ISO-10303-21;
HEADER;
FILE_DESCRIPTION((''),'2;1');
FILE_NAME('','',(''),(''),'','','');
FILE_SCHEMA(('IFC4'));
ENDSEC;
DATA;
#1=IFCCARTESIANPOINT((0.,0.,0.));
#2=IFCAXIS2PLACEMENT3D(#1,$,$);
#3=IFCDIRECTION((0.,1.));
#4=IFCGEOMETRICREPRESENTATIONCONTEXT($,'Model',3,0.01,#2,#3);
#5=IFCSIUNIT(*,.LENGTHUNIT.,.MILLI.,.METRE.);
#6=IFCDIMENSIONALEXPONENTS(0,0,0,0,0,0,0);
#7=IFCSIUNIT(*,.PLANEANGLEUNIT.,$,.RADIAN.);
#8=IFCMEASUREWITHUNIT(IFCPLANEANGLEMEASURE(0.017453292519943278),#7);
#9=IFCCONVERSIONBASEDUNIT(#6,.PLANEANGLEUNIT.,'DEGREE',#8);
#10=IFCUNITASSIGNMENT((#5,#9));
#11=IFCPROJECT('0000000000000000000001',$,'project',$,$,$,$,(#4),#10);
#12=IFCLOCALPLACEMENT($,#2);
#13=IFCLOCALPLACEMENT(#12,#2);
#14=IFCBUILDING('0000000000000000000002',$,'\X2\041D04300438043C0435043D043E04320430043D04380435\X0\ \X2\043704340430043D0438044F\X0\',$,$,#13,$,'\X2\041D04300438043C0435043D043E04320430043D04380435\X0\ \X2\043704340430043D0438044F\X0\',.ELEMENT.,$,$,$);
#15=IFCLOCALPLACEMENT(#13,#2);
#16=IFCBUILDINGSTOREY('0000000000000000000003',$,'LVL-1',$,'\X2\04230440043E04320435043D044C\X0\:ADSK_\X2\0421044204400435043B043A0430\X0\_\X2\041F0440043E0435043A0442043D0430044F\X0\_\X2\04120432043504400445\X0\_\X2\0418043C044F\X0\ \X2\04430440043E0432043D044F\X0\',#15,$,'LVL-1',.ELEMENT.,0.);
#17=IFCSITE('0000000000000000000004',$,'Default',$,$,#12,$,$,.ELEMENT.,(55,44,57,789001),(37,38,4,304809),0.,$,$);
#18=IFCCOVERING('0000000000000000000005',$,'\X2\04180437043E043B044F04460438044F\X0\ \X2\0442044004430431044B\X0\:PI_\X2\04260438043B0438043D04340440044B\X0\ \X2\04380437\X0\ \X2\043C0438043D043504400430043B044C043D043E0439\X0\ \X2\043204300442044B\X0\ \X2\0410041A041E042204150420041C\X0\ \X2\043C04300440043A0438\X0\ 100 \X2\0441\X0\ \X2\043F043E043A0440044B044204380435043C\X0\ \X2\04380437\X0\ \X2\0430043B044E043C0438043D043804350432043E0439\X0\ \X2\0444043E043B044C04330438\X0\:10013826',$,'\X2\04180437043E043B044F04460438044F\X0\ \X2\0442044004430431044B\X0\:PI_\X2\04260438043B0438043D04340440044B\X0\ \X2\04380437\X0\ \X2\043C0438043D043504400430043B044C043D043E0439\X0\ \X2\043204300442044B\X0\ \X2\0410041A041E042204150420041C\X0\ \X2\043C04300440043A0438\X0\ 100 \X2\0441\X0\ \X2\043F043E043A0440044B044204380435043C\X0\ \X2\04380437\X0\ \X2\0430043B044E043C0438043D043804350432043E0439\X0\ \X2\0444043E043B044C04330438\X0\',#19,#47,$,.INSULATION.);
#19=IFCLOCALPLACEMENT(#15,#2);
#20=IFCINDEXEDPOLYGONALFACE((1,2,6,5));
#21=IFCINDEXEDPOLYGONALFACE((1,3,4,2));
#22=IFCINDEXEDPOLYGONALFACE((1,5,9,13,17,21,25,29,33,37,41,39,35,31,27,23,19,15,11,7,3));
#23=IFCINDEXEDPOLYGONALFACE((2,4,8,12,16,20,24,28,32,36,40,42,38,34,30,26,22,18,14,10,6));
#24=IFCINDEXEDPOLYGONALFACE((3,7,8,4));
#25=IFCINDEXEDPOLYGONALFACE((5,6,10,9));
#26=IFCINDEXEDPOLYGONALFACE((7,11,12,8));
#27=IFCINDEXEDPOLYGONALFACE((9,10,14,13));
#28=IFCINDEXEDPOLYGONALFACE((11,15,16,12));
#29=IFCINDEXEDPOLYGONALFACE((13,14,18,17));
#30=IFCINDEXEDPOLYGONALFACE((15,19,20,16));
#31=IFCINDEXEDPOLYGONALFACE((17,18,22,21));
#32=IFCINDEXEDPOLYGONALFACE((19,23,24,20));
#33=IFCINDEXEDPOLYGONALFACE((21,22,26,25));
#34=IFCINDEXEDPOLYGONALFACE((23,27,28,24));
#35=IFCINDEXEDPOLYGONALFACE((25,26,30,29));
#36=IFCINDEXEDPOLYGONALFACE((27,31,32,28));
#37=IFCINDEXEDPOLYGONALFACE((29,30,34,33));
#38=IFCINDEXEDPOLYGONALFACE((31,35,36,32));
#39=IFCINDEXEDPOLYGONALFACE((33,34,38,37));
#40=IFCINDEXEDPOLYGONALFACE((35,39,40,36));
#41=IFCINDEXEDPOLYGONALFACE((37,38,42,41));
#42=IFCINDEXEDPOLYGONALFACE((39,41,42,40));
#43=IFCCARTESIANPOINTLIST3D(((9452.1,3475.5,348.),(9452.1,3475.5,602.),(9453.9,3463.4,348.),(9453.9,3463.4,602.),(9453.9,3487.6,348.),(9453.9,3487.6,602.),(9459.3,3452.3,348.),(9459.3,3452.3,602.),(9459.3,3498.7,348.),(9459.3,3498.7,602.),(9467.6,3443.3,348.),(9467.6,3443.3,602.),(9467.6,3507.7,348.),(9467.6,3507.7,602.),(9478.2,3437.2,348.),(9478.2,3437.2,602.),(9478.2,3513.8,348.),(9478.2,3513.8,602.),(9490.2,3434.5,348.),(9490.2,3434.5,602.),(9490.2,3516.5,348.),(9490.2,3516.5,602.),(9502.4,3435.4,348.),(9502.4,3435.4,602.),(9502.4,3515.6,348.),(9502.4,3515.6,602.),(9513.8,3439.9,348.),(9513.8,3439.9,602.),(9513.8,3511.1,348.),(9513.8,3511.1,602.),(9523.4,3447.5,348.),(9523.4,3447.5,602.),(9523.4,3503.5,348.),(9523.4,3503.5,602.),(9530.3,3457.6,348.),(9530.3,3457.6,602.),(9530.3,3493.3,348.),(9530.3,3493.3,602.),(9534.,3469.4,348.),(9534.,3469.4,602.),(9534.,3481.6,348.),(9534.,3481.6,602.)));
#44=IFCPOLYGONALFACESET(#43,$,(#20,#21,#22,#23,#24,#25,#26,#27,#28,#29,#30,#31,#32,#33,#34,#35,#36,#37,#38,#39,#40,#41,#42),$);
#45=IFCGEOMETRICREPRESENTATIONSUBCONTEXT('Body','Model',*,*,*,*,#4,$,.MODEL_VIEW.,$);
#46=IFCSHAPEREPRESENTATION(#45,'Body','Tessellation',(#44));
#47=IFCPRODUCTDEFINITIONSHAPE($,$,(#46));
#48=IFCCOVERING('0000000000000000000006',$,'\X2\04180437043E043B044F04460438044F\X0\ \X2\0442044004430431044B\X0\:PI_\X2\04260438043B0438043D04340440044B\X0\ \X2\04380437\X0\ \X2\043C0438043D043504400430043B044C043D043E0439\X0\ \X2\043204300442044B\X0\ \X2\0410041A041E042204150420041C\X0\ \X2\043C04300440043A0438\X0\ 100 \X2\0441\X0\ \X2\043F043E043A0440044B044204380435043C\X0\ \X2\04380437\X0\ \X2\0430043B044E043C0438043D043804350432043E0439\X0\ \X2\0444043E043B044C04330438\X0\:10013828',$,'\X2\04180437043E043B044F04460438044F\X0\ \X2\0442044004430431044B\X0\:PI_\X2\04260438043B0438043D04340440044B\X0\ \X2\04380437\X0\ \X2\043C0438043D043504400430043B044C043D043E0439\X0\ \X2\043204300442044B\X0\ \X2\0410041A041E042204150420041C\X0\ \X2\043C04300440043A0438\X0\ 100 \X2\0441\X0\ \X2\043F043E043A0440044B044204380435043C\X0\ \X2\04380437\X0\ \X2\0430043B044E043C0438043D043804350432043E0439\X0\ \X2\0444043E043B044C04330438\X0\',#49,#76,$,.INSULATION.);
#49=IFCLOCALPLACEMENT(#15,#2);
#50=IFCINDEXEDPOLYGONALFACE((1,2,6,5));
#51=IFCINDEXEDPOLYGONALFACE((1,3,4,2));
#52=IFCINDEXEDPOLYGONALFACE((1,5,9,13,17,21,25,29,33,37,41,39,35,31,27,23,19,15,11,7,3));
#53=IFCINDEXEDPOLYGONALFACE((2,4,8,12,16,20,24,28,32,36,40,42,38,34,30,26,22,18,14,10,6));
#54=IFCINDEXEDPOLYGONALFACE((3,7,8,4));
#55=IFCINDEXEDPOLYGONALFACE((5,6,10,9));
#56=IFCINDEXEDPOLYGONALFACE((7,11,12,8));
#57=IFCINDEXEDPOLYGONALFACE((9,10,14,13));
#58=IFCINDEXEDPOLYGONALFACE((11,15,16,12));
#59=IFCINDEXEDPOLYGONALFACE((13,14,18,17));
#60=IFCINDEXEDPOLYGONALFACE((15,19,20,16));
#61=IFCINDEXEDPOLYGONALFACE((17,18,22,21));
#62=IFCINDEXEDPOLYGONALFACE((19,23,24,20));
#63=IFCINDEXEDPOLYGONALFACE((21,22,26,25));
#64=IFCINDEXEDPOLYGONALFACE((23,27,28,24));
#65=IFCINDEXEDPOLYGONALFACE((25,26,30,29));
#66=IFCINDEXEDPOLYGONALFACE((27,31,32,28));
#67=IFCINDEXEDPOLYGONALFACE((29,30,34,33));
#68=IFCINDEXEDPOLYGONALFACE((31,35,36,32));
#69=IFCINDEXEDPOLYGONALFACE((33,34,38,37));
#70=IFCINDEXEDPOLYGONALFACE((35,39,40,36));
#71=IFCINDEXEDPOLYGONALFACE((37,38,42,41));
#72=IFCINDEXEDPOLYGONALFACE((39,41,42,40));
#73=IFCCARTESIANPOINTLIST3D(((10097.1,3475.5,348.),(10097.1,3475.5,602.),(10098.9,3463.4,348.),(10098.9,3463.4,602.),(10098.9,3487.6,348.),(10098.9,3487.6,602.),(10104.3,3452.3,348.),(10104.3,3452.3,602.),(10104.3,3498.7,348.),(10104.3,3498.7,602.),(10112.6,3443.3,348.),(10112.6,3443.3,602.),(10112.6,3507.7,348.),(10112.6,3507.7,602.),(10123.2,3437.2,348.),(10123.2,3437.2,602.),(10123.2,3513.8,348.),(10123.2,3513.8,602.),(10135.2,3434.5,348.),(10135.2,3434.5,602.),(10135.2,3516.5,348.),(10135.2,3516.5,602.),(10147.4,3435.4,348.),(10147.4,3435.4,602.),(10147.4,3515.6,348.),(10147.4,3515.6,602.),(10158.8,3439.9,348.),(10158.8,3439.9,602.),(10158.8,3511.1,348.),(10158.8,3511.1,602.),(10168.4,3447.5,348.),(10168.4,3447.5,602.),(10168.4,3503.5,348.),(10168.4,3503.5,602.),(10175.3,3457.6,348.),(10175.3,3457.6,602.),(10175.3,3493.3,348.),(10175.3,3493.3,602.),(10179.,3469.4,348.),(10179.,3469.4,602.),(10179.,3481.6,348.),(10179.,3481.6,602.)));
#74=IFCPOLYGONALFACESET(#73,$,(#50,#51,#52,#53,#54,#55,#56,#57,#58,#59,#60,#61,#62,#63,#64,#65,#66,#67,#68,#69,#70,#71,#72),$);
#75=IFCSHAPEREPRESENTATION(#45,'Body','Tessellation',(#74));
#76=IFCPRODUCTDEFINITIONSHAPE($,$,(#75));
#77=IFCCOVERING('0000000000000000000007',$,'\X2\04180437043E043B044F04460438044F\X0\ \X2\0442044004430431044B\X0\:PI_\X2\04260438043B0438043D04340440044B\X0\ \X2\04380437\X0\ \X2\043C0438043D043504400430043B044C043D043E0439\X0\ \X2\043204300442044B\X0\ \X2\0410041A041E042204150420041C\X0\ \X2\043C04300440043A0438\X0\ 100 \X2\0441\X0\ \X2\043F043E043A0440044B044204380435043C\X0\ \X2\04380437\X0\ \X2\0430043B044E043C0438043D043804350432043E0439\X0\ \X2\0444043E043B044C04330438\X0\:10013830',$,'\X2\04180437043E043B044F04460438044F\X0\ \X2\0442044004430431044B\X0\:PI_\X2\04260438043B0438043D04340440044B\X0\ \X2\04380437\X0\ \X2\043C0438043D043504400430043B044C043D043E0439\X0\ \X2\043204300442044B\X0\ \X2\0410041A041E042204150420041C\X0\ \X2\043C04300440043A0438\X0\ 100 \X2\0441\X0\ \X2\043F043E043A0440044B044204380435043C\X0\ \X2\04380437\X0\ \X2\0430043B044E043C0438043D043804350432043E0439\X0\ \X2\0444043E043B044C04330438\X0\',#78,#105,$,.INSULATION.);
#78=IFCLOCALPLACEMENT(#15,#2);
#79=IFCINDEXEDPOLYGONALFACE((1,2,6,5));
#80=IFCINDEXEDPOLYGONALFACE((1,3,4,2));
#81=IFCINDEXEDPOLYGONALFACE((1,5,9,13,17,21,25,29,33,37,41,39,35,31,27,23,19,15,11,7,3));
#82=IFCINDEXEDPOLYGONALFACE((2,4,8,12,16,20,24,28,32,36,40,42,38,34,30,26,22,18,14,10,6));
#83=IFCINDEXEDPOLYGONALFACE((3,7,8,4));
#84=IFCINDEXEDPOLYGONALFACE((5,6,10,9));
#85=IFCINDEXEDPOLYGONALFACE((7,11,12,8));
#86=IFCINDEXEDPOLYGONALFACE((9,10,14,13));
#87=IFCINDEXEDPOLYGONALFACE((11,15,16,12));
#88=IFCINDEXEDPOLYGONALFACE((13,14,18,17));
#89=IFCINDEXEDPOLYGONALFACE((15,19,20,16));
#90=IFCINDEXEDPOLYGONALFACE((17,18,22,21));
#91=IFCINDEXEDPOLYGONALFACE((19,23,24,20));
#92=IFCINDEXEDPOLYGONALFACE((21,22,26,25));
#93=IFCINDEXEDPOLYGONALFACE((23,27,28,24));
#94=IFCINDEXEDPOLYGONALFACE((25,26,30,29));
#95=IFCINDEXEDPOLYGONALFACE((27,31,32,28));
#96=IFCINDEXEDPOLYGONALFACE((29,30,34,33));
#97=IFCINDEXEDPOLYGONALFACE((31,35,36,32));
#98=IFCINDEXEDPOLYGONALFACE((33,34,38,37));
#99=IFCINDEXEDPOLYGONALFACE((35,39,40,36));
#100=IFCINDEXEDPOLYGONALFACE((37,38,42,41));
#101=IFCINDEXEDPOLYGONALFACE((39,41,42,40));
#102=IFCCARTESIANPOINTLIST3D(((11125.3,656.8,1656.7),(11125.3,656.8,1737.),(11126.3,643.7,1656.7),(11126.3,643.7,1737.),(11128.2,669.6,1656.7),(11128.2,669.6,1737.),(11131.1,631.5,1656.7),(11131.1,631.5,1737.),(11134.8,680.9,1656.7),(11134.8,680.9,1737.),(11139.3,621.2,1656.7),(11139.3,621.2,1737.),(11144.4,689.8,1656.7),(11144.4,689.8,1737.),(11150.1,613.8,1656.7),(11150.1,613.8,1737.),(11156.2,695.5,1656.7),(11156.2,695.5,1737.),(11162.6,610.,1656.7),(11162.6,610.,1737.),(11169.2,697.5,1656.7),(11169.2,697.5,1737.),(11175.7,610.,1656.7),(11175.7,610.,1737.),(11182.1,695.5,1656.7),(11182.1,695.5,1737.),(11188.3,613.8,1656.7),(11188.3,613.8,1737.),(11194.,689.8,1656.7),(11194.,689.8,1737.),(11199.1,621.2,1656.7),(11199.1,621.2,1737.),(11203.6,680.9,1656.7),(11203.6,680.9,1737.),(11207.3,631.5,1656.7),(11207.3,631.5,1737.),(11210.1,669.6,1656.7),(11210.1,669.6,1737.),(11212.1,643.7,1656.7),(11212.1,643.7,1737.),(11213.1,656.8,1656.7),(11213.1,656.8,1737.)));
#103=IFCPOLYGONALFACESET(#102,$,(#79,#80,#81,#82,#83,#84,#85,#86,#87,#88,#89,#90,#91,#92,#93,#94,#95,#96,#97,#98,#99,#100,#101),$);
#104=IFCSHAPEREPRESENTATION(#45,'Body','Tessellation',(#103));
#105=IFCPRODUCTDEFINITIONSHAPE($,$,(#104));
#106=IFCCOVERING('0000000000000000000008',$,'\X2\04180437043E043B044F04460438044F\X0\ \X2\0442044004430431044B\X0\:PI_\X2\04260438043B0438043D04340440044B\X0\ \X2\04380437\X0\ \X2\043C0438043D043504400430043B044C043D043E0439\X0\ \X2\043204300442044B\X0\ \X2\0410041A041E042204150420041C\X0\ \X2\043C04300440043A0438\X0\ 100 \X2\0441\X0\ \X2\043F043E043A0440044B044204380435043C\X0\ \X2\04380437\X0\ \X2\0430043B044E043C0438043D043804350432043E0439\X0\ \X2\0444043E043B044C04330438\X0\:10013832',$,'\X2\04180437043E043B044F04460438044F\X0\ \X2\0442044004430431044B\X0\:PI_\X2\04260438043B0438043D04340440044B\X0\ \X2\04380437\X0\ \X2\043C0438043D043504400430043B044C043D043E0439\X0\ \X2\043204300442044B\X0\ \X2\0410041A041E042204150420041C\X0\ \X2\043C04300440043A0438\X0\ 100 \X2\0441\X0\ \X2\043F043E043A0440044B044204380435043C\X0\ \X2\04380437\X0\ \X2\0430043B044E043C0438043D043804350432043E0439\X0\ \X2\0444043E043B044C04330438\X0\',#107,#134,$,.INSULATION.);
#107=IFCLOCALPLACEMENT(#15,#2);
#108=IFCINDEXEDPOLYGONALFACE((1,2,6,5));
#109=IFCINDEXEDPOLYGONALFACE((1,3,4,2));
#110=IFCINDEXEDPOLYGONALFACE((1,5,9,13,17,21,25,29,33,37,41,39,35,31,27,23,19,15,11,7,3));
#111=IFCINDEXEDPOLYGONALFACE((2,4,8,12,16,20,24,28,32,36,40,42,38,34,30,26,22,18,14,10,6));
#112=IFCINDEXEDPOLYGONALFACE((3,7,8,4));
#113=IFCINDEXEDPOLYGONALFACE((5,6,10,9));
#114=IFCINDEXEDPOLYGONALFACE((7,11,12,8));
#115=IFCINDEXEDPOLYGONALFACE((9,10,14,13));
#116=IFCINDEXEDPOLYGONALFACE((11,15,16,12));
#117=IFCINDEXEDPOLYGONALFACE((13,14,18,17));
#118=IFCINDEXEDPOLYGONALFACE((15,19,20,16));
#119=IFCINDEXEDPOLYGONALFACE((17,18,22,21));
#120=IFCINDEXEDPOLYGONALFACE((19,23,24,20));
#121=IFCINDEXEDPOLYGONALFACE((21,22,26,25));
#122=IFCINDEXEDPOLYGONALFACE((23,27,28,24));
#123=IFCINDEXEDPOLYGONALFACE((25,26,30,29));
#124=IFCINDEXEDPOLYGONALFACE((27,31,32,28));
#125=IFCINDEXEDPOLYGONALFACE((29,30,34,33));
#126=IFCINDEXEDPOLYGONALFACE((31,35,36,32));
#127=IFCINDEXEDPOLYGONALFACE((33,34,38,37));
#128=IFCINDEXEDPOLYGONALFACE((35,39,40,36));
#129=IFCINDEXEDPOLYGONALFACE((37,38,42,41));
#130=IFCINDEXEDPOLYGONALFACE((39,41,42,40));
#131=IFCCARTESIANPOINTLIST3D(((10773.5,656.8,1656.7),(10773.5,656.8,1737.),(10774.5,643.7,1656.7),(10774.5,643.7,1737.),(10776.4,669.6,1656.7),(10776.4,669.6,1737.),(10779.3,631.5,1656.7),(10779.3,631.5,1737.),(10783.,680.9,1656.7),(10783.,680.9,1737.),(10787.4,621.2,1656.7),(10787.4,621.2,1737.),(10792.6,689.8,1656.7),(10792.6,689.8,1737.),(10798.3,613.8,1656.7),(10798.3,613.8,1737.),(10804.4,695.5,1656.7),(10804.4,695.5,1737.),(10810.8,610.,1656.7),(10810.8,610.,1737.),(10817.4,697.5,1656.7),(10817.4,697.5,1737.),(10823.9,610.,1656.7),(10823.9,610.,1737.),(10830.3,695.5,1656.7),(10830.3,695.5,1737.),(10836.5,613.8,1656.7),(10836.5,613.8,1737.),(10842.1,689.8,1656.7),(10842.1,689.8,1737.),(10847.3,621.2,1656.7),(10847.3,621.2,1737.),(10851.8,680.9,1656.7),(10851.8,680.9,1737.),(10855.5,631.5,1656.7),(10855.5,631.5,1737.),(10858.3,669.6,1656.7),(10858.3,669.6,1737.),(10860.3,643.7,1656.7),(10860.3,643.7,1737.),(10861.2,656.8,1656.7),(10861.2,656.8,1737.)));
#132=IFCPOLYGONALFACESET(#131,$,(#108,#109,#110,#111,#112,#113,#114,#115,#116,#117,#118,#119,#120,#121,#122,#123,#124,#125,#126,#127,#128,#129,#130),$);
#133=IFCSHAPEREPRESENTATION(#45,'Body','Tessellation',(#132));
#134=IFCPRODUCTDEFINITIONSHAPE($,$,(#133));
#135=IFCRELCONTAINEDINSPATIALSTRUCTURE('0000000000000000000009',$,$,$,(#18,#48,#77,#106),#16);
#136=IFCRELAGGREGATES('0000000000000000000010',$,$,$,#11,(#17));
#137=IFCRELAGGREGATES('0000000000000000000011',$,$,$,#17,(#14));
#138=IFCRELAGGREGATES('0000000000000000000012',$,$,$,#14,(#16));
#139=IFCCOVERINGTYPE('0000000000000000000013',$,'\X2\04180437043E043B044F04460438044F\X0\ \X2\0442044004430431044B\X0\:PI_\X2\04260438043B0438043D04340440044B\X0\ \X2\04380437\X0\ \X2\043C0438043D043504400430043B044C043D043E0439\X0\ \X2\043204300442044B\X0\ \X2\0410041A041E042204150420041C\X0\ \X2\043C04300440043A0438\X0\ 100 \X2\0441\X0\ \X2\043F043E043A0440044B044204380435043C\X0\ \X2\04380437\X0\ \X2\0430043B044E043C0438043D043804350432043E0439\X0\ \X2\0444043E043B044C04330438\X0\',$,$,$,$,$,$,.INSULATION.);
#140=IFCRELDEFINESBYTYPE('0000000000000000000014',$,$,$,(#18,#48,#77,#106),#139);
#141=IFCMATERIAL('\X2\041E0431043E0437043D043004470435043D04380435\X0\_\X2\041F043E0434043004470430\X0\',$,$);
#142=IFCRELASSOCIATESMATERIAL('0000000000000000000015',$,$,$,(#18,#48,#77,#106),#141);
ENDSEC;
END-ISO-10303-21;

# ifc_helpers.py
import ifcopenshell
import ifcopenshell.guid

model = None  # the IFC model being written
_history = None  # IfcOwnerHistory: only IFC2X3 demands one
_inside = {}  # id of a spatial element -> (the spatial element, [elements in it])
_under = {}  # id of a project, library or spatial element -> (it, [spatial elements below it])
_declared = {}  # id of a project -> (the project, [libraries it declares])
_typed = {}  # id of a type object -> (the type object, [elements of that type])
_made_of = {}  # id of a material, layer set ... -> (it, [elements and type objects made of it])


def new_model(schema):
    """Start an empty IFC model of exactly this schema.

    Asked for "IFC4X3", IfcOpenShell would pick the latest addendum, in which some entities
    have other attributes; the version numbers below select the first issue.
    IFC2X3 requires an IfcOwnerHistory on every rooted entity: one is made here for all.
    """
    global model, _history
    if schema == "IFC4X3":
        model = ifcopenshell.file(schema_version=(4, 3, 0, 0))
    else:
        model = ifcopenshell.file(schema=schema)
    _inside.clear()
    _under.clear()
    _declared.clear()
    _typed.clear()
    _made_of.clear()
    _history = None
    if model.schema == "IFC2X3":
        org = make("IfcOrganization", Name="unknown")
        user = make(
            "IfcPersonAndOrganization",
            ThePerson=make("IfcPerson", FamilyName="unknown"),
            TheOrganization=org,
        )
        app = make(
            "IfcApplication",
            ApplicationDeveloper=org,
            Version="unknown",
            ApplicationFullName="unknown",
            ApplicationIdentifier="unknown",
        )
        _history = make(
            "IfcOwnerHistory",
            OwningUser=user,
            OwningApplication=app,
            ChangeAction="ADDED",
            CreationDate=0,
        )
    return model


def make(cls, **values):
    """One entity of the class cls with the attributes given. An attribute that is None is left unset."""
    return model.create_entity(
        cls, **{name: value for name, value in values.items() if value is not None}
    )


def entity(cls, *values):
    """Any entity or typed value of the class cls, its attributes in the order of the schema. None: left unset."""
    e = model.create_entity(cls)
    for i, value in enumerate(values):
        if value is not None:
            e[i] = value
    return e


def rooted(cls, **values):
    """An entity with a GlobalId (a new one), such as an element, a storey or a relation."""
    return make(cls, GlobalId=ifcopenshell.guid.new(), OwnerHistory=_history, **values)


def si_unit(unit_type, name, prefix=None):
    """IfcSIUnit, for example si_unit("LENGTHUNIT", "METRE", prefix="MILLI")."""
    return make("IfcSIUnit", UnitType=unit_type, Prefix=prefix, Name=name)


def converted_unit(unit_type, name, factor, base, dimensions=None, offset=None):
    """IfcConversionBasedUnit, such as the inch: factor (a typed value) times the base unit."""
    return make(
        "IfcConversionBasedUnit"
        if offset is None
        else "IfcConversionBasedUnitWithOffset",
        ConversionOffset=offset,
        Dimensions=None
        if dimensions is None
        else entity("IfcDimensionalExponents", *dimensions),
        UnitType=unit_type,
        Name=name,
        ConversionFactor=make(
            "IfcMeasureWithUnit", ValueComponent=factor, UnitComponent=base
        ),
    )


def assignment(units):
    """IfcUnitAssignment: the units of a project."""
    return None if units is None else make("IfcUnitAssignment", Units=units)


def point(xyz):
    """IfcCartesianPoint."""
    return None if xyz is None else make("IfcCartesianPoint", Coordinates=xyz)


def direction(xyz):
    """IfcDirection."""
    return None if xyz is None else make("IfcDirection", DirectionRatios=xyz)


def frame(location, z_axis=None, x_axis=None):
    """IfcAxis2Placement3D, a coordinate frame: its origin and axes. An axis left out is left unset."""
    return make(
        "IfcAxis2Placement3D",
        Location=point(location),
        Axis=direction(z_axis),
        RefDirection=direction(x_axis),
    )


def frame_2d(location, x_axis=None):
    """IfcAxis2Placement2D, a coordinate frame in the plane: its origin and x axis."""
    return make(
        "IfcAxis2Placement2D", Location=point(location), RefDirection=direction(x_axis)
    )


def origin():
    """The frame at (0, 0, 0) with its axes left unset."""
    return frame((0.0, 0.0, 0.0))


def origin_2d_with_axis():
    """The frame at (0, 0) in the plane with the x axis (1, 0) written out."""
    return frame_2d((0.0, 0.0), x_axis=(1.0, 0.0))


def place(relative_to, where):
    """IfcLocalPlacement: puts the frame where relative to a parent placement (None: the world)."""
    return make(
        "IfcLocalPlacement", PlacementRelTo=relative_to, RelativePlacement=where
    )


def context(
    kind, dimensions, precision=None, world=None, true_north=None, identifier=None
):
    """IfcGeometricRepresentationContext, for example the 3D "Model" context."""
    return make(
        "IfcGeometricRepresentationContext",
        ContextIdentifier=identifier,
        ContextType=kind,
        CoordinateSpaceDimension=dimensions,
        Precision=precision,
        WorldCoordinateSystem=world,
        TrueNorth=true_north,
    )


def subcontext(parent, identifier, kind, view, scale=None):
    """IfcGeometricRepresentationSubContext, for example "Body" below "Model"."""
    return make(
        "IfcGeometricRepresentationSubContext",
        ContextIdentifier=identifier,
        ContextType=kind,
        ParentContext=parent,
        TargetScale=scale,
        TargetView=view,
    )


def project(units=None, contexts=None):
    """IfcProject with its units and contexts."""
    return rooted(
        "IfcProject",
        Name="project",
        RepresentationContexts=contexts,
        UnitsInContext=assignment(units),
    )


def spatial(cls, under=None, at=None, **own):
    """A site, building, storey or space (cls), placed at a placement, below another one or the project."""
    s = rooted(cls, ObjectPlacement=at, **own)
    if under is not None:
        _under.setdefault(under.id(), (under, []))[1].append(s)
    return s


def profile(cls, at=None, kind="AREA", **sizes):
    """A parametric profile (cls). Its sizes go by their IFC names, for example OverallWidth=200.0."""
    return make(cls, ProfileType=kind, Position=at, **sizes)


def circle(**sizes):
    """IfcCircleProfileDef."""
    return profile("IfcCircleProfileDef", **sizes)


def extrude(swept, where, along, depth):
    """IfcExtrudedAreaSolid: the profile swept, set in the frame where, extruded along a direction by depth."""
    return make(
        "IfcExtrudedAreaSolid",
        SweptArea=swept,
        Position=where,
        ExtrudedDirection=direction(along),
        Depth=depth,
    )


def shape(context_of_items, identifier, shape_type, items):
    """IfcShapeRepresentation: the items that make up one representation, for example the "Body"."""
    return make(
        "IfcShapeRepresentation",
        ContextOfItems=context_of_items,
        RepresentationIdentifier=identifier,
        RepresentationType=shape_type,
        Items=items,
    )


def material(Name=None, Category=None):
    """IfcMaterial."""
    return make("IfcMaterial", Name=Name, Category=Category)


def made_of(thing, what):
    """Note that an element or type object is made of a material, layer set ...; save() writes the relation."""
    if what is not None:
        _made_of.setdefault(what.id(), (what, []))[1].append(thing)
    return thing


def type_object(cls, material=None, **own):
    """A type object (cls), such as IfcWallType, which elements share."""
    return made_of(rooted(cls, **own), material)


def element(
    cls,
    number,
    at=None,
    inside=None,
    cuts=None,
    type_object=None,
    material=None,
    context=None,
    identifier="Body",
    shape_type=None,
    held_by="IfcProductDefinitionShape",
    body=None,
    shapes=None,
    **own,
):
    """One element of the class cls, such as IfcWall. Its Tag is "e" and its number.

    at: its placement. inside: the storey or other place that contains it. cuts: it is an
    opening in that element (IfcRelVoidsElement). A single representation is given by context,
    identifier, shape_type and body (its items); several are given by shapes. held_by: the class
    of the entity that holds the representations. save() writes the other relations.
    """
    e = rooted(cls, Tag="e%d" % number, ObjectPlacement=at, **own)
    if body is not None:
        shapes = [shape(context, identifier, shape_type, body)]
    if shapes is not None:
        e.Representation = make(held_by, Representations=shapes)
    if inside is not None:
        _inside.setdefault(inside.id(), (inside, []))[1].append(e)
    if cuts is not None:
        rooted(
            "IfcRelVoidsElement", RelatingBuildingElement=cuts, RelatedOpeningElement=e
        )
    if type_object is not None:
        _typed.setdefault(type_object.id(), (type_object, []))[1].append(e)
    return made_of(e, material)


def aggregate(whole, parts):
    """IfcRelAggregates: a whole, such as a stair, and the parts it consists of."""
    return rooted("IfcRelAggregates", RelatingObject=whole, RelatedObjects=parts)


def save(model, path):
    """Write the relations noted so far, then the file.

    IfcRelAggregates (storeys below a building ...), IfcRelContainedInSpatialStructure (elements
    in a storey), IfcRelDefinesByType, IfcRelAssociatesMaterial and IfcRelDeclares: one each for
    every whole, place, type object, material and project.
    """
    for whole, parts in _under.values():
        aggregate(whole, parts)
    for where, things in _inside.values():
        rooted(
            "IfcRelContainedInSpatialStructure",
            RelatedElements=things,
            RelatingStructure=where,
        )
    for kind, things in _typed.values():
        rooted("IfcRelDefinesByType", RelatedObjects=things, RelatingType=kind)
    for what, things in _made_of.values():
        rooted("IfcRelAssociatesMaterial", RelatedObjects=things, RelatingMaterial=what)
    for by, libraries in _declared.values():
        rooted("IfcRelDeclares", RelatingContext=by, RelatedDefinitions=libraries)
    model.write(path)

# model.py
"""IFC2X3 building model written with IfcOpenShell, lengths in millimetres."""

from ifc_helpers import new_model, entity, si_unit, converted_unit, direction, frame, frame_2d, origin, origin_2d_with_axis, place, context, subcontext, project, spatial, circle, extrude, material, type_object, element, save


model = new_model("IFC2X3")

# Units and contexts
model_context = context("Model", 3, precision=0.01, world=origin(), true_north=direction((0.0, 1.0)))
body_context = subcontext(model_context, "Body", "Model", "MODEL_VIEW")
ifc_project = project(units=[si_unit("LENGTHUNIT", "METRE", prefix="MILLI"), converted_unit("PLANEANGLEUNIT", "DEGREE", entity("IfcPlaneAngleMeasure", 0.017453292519943278), si_unit("PLANEANGLEUNIT", "RADIAN"), dimensions=[0, 0, 0, 0, 0, 0, 0])], contexts=[model_context])

# Site, building, storey
site_placement = place(None, origin())
site = spatial("IfcSite", under=ifc_project, at=site_placement, Name="Default", CompositionType="ELEMENT", RefLatitude=(55, 44, 57, 789001), RefLongitude=(37, 38, 4, 304809), RefElevation=0.0)
building_placement = place(site_placement, origin())
building = spatial("IfcBuilding", under=site, at=building_placement, Name="Наименование здания", LongName="Наименование здания", CompositionType="ELEMENT")
storey_placement = place(building_placement, origin())
storey = spatial("IfcBuildingStorey", under=building, at=storey_placement, Name="LVL-1", ObjectType="Уровень:ADSK_Стрелка_Проектная_Вверх_Имя уровня", LongName="LVL-1", CompositionType="ELEMENT", Elevation=0.0)

# Coverings
ifc_material_1 = material(Name="Обозначение_Подача")
covering_type = type_object("IfcCoveringType", Name="Изоляция трубы:PI_Цилиндры из минеральной ваты АКОТЕРМ марки 100 с покрытием из алюминиевой фольги", PredefinedType="INSULATION")
covering_1_placement = place(storey_placement, origin())
element("IfcCovering", 1, at=covering_1_placement, inside=storey, type_object=covering_type, material=ifc_material_1, Name="Изоляция трубы:PI_Цилиндры из минеральной ваты АКОТЕРМ марки 100 с покрытием из алюминиевой фольги:10013826", ObjectType="Изоляция трубы:PI_Цилиндры из минеральной ваты АКОТЕРМ марки 100 с покрытием из алюминиевой фольги", PredefinedType="INSULATION", context=body_context, shape_type="SweptSolid", body=[
    extrude(circle(Radius=41.1, at=frame_2d((0.0, 0.0), x_axis=(1.0, 0.0))), frame((9493.3, 3475.5, 348.0), z_axis=(0.0, 0.0, 1.0), x_axis=(-1.0, 0.0, 0.0)), (0.0, 0.0, 1.0), 254.0),
])
covering_2_placement = place(storey_placement, origin())
element("IfcCovering", 2, at=covering_2_placement, inside=storey, type_object=covering_type, material=ifc_material_1, Name="Изоляция трубы:PI_Цилиндры из минеральной ваты АКОТЕРМ марки 100 с покрытием из алюминиевой фольги:10013828", ObjectType="Изоляция трубы:PI_Цилиндры из минеральной ваты АКОТЕРМ марки 100 с покрытием из алюминиевой фольги", PredefinedType="INSULATION", context=body_context, shape_type="SweptSolid", body=[
    extrude(circle(Radius=41.1, at=origin_2d_with_axis()), frame((10138.3, 3475.5, 348.0), z_axis=(0.0, 0.0, 1.0), x_axis=(-1.0, 0.0, 0.0)), (0.0, 0.0, 1.0), 254.0),
])
covering_3_placement = place(storey_placement, origin())
element("IfcCovering", 3, at=covering_3_placement, inside=storey, type_object=covering_type, material=ifc_material_1, Name="Изоляция трубы:PI_Цилиндры из минеральной ваты АКОТЕРМ марки 100 с покрытием из алюминиевой фольги:10013830", ObjectType="Изоляция трубы:PI_Цилиндры из минеральной ваты АКОТЕРМ марки 100 с покрытием из алюминиевой фольги", PredefinedType="INSULATION", context=body_context, shape_type="SweptSolid", body=[
    extrude(circle(Radius=44.0, at=frame_2d((0.0, 0.0), x_axis=(1.0, 0.0))), frame((11169.2, 653.5, 1656.7), z_axis=(0.0, 0.0, 1.0), x_axis=(0.0, 1.0, 0.0)), (0.0, 0.0, 1.0), 80.3),
])
covering_4_placement = place(storey_placement, origin())
element("IfcCovering", 4, at=covering_4_placement, inside=storey, type_object=covering_type, material=ifc_material_1, Name="Изоляция трубы:PI_Цилиндры из минеральной ваты АКОТЕРМ марки 100 с покрытием из алюминиевой фольги:10013832", ObjectType="Изоляция трубы:PI_Цилиндры из минеральной ваты АКОТЕРМ марки 100 с покрытием из алюминиевой фольги", PredefinedType="INSULATION", context=body_context, shape_type="SweptSolid", body=[
    extrude(circle(Radius=44.0, at=frame_2d((0.0, 0.0), x_axis=(1.0, 0.0))), frame((10817.4, 653.5, 1656.7), z_axis=(0.0, 0.0, 1.0), x_axis=(0.0, 1.0, 0.0)), (0.0, 0.0, 1.0), 80.3),
])

save(model, "model.ifc")
